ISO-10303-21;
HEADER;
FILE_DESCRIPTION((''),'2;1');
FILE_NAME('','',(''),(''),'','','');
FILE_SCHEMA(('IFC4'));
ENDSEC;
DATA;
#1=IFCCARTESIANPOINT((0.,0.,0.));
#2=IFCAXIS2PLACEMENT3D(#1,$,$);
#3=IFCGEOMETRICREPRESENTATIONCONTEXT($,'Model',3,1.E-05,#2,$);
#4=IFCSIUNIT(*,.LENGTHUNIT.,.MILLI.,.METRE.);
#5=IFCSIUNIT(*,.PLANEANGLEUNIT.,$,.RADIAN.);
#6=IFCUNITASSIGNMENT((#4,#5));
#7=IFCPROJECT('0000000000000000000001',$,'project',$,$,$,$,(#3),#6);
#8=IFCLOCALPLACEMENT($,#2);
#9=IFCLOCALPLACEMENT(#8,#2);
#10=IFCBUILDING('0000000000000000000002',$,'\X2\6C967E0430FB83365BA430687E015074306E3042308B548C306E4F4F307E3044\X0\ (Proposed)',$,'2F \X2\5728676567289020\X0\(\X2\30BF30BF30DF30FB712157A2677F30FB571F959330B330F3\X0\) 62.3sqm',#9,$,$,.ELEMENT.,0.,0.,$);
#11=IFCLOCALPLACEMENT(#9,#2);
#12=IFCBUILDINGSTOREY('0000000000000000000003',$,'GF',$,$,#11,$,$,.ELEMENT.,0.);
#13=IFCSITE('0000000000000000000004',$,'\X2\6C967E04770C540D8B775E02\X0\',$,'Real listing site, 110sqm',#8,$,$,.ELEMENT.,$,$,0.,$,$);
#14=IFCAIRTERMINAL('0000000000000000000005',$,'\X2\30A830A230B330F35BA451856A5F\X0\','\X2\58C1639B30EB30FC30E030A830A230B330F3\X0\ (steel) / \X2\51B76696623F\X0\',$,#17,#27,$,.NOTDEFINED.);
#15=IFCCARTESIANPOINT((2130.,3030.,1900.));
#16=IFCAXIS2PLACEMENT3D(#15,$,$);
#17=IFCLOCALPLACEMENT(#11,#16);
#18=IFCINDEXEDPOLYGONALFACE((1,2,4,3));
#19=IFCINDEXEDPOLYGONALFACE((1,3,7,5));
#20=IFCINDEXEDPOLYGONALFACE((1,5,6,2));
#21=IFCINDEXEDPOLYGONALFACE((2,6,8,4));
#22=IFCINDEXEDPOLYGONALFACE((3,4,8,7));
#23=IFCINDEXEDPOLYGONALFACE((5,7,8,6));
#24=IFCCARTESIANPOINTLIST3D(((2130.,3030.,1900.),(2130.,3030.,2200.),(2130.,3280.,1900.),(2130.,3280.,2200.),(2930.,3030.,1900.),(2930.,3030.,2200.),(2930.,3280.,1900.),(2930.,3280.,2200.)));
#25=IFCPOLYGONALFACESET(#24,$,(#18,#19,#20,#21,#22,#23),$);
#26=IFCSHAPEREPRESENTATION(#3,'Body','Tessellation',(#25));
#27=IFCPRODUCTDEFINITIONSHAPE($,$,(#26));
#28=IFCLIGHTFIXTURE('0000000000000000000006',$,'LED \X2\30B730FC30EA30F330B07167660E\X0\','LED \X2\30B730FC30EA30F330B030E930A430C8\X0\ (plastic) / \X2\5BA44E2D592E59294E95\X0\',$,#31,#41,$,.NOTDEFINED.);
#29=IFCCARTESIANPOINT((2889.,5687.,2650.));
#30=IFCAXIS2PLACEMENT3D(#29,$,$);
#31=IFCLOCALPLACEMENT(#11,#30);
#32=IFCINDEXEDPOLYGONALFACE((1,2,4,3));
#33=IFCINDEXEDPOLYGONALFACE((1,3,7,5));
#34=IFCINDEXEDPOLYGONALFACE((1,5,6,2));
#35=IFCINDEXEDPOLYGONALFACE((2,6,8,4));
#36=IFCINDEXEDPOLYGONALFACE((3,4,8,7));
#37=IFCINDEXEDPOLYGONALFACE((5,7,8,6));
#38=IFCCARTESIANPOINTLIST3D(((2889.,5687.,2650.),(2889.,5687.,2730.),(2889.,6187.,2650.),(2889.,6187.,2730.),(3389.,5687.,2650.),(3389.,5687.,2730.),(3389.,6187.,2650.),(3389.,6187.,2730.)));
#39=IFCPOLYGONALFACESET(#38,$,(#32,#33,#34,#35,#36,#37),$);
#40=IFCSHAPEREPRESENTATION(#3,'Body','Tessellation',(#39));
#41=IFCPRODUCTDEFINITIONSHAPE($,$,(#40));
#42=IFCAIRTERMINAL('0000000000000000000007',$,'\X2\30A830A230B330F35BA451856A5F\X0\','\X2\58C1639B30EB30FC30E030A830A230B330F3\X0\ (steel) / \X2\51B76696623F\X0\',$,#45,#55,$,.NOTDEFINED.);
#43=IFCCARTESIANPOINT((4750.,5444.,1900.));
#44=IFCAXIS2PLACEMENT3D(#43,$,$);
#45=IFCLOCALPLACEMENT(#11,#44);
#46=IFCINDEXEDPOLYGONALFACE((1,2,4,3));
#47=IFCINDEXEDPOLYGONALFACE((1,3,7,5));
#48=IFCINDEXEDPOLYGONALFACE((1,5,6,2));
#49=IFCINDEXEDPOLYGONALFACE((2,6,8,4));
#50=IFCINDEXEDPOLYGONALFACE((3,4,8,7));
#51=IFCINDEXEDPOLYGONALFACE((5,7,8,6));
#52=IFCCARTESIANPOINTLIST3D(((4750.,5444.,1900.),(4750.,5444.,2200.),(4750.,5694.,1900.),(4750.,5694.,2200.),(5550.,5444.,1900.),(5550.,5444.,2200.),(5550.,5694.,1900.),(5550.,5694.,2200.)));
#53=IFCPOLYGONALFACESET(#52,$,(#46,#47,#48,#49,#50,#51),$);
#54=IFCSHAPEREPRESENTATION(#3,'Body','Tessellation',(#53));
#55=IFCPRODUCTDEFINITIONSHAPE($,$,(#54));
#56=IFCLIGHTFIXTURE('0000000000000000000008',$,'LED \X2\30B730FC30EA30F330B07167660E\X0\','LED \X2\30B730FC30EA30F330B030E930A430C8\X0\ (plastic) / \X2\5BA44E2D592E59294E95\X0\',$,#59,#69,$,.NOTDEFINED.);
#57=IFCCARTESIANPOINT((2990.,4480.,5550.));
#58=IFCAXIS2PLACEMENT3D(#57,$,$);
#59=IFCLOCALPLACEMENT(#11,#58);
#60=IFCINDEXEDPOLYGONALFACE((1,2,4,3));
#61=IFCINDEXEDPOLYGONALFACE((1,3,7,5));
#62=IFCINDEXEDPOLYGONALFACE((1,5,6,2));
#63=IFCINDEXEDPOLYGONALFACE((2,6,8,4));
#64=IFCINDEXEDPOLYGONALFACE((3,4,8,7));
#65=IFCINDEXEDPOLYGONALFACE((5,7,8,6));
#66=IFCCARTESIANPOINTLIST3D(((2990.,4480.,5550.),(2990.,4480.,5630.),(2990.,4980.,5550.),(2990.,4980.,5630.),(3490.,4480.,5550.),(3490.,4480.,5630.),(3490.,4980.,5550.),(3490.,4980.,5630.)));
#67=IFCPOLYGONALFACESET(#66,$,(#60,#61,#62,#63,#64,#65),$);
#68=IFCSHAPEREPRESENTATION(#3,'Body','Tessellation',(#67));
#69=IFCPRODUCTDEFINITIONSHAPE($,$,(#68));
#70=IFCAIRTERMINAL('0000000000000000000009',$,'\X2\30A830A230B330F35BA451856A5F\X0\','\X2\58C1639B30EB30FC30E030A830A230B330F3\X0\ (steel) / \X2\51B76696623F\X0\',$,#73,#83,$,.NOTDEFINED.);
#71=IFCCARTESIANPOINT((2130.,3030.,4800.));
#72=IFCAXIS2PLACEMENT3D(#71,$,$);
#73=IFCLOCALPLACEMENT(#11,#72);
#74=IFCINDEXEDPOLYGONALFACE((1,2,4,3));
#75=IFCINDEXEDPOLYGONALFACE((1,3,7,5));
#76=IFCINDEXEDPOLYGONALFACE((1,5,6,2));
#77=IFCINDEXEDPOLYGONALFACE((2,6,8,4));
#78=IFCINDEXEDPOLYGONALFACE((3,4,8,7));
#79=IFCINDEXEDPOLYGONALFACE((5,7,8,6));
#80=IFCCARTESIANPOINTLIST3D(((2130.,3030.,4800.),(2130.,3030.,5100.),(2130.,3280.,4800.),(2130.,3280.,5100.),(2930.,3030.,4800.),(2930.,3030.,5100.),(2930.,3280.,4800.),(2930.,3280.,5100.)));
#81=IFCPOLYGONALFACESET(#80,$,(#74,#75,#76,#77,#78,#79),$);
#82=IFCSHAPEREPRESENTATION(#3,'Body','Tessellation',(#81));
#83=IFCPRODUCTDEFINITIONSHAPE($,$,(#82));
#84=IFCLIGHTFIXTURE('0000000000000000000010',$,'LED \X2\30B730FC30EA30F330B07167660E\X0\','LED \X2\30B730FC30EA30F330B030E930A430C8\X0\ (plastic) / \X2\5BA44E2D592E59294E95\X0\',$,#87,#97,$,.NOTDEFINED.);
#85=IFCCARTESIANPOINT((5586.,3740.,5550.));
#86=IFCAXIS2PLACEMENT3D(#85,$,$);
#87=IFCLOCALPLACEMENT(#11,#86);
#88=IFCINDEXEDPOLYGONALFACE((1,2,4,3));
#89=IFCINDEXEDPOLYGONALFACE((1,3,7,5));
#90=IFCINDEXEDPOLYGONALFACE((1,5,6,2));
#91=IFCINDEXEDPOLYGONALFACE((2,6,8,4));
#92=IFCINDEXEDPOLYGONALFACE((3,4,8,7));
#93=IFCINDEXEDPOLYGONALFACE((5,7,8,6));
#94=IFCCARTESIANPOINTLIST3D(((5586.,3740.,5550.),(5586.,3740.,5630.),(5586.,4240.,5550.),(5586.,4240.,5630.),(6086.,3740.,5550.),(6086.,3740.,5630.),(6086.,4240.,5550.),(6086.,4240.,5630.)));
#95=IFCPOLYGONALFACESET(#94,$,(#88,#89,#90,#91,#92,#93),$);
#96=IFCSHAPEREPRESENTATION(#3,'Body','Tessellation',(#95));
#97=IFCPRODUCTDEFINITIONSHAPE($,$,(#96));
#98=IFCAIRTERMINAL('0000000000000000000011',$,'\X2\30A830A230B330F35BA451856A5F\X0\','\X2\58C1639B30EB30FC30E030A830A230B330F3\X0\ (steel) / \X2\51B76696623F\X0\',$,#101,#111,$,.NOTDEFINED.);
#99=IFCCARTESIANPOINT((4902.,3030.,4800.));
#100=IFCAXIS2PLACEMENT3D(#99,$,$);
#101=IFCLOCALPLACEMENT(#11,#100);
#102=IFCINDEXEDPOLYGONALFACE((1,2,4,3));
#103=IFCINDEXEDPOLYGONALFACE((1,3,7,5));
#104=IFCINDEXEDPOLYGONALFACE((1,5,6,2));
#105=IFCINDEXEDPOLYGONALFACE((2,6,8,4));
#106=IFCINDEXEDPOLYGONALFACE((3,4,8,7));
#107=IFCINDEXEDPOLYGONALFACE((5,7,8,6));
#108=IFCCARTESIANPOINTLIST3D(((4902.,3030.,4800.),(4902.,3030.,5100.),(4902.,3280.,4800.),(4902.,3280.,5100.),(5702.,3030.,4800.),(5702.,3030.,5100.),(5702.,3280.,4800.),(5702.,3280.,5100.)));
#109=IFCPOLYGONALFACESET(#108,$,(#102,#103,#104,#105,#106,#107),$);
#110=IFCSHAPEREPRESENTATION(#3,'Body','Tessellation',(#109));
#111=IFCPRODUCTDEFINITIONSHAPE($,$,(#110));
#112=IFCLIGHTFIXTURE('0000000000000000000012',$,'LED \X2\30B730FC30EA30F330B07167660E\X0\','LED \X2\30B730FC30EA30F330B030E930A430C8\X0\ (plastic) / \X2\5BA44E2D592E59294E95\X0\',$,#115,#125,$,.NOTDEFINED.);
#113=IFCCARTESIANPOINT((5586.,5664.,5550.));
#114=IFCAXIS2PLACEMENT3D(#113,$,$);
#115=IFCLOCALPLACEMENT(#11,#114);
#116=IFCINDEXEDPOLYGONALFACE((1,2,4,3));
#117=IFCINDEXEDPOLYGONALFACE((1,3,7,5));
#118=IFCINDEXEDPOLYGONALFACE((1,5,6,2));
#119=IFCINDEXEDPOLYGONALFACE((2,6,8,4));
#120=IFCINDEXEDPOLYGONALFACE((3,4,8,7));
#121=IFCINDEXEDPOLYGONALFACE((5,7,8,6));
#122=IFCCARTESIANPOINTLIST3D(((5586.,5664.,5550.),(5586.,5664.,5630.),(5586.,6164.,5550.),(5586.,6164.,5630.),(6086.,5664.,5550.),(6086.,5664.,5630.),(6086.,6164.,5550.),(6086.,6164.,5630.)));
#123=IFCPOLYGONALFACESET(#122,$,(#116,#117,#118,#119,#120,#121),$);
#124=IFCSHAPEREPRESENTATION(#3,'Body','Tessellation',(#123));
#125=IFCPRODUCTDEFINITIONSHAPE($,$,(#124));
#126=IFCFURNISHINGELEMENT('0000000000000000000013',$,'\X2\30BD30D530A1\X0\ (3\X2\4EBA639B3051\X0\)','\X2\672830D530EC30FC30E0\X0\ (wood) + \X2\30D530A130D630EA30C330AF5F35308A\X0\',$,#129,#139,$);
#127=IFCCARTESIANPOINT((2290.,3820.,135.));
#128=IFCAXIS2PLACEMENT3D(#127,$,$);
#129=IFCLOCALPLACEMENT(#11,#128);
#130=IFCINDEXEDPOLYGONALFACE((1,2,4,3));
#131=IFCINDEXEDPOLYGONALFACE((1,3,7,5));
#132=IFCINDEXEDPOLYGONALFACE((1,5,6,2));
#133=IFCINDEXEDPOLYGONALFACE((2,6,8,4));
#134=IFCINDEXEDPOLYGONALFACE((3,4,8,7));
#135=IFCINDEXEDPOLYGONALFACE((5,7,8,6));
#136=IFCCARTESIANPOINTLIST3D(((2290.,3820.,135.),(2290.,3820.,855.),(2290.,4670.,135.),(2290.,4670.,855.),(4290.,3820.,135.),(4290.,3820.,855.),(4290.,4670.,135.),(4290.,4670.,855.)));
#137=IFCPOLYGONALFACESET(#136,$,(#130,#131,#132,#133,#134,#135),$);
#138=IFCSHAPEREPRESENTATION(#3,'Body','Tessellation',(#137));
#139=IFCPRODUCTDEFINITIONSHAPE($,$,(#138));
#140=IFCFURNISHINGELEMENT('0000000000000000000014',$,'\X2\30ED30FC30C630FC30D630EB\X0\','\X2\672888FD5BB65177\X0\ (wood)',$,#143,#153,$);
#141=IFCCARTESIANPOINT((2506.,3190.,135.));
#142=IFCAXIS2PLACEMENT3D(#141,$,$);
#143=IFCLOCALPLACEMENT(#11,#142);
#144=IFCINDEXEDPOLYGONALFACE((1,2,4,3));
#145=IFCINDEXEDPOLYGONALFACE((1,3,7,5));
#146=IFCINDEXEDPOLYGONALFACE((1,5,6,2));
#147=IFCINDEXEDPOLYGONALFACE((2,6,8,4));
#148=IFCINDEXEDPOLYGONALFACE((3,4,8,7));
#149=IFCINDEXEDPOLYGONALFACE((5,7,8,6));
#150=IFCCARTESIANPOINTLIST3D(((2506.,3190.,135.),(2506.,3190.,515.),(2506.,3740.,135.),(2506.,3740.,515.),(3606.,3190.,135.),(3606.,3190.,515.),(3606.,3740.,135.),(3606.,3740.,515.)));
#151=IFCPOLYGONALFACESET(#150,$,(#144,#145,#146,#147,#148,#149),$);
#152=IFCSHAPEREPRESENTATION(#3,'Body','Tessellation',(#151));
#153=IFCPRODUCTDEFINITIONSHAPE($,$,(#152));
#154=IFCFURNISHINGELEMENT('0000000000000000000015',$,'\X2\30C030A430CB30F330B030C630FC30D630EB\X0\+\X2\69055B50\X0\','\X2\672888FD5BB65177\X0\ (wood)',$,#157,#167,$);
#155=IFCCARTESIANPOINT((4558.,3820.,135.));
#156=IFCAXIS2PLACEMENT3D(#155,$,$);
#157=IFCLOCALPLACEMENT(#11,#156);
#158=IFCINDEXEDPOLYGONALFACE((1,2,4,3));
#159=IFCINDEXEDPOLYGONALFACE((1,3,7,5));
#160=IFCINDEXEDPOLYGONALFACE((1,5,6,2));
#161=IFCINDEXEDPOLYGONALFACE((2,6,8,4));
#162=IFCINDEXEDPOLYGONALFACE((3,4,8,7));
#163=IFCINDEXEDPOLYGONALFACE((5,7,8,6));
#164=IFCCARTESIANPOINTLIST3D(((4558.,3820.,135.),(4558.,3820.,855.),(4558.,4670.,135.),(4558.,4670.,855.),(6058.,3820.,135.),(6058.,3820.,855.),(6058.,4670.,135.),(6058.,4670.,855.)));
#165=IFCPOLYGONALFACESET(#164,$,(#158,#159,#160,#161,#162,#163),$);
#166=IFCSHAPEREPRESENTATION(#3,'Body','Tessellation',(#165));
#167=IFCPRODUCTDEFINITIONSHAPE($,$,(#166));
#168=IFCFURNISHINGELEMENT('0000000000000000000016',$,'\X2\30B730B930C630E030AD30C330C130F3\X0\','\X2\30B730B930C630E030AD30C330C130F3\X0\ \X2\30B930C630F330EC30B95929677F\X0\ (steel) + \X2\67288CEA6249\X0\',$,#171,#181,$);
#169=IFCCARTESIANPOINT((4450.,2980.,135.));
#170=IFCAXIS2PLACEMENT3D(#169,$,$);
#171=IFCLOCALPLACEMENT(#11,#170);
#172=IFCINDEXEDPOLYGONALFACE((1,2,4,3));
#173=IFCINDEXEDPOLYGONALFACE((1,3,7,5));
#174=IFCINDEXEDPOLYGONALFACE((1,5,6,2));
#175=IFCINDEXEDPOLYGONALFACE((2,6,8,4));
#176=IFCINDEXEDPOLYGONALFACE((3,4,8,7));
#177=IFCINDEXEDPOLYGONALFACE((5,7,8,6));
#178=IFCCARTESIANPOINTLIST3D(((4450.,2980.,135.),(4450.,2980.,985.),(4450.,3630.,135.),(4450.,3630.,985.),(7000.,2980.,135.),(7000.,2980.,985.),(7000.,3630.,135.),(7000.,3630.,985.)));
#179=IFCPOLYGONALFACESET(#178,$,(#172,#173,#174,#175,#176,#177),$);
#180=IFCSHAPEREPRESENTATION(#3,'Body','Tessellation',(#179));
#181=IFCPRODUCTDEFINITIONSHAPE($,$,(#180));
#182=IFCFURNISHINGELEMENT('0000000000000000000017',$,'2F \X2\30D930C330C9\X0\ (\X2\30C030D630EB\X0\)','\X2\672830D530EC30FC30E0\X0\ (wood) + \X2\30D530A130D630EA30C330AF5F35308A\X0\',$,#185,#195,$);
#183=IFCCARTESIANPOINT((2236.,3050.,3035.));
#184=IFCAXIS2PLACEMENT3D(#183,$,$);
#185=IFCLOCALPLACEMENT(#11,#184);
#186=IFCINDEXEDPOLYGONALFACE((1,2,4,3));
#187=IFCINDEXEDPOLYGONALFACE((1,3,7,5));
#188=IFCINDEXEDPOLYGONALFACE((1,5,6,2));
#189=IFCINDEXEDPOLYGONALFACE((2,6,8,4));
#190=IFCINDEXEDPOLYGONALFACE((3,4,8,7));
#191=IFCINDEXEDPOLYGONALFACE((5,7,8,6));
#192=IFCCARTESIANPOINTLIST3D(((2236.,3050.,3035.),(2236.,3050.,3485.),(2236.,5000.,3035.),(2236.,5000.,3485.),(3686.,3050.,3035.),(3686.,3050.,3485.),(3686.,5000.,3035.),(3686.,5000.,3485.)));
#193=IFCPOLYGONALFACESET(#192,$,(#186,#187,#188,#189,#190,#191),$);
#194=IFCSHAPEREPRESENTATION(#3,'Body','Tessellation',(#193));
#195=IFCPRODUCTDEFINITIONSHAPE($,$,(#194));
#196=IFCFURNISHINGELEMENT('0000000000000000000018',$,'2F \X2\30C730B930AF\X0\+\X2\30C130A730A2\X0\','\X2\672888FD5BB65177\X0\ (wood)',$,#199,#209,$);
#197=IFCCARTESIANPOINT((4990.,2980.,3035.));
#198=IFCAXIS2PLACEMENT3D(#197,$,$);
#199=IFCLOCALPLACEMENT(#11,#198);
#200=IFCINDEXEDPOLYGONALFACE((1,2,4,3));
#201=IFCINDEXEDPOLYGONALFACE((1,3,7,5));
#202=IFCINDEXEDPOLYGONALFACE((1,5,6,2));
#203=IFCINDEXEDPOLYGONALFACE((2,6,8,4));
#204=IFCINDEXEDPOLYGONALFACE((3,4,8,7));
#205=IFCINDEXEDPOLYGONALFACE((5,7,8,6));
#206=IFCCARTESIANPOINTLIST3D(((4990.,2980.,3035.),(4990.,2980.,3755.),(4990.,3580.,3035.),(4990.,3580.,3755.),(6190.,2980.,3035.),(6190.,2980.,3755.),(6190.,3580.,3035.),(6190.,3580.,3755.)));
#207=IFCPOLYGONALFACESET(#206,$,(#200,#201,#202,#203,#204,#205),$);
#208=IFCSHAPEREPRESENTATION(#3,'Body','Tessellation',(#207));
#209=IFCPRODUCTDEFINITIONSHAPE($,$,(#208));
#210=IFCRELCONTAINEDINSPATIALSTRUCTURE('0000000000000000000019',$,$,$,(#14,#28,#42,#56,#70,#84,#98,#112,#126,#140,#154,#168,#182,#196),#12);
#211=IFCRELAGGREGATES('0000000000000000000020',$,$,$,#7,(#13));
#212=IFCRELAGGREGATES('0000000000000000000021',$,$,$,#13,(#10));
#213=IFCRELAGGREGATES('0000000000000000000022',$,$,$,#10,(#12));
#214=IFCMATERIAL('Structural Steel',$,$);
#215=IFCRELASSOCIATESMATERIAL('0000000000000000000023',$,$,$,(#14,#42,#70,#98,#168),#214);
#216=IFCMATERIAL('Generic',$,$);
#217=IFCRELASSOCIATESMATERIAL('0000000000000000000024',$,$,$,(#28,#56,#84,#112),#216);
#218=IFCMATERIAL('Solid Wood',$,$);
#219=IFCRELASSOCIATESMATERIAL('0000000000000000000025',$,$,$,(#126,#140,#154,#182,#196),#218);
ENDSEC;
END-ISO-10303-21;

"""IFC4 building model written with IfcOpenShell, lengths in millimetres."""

from ifc_helpers import new_model, si_unit, frame, frame_2d, origin, place, context, project, spatial, rectangle, extrude, material, element, save


model = new_model("IFC4")

# Units and contexts
model_context = context("Model", 3, precision=1e-05, world=origin())
ifc_project = project(units=[si_unit("LENGTHUNIT", "METRE", prefix="MILLI"), si_unit("PLANEANGLEUNIT", "RADIAN")], contexts=[model_context])

# Site, building, storey
site_placement = place(None, origin())
site = spatial("IfcSite", under=ifc_project, at=site_placement, Name="沖縄県名護市", ObjectType="Real listing site, 110sqm", CompositionType="ELEMENT", RefElevation=0.0)
building_placement = place(site_placement, origin())
building = spatial("IfcBuilding", under=site, at=building_placement, Name="沖縄・茶室と縁側のある和の住まい (Proposed)", ObjectType="2F 在来木造(タタミ・無垢板・土間コン) 62.3sqm", CompositionType="ELEMENT", ElevationOfRefHeight=0.0, ElevationOfTerrain=0.0)
storey_placement = place(building_placement, origin())
storey = spatial("IfcBuildingStorey", under=building, at=storey_placement, Name="GF", CompositionType="ELEMENT", Elevation=0.0)

# Shared definitions
ifc_material_1 = material(Name="Solid Wood")

# Shared definitions
ifc_material_2 = material(Name="Structural Steel")

# Shared definitions
ifc_material_3 = material(Name="Generic")

# Air terminal
air_terminal_1_placement = place(storey_placement, frame((2130.0, 3030.0, 1900.0)))
element("IfcAirTerminal", 1, at=air_terminal_1_placement, inside=storey, material=ifc_material_2, Name="エアコン室内機", Description="壁掛ルームエアコン (steel) / 冷暖房", PredefinedType="NOTDEFINED", context=model_context, shape_type="SweptSolid", body=[
    extrude(rectangle(XDim=800.0, YDim=250.0, at=frame_2d((400.0, 125.0))), frame((2130.0, 3030.0, 1900.0)), (0.0, 0.0, 1.0), 300.0),
])

# Light fixture
light_fixture_1_placement = place(storey_placement, frame((2889.0, 5687.0, 2650.0)))
element("IfcLightFixture", 2, at=light_fixture_1_placement, inside=storey, material=ifc_material_3, Name="LED シーリング照明", Description="LED シーリングライト (plastic) / 室中央天井", PredefinedType="NOTDEFINED", context=model_context, shape_type="SweptSolid", body=[
    extrude(rectangle(XDim=500.0, YDim=500.0, at=frame_2d((250.0, 250.0))), frame((2889.0, 5687.0, 2650.0)), (0.0, 0.0, 1.0), 80.0),
])

# Air terminal
air_terminal_2_placement = place(storey_placement, frame((4750.0, 5444.0, 1900.0)))
element("IfcAirTerminal", 3, at=air_terminal_2_placement, inside=storey, material=ifc_material_2, Name="エアコン室内機", Description="壁掛ルームエアコン (steel) / 冷暖房", PredefinedType="NOTDEFINED", context=model_context, shape_type="SweptSolid", body=[
    extrude(rectangle(XDim=800.0, YDim=250.0, at=frame_2d((400.0, 125.0))), frame((4750.0, 5444.0, 1900.0)), (0.0, 0.0, 1.0), 300.0),
])

# Light fixture
light_fixture_2_placement = place(storey_placement, frame((2990.0, 4480.0, 5550.0)))
element("IfcLightFixture", 4, at=light_fixture_2_placement, inside=storey, material=ifc_material_3, Name="LED シーリング照明", Description="LED シーリングライト (plastic) / 室中央天井", PredefinedType="NOTDEFINED", context=model_context, shape_type="SweptSolid", body=[
    extrude(rectangle(XDim=500.0, YDim=500.0, at=frame_2d((250.0, 250.0))), frame((2990.0, 4480.0, 5550.0)), (0.0, 0.0, 1.0), 80.0),
])

# Air terminal
air_terminal_3_placement = place(storey_placement, frame((2130.0, 3030.0, 4800.0)))
element("IfcAirTerminal", 5, at=air_terminal_3_placement, inside=storey, material=ifc_material_2, Name="エアコン室内機", Description="壁掛ルームエアコン (steel) / 冷暖房", PredefinedType="NOTDEFINED", context=model_context, shape_type="SweptSolid", body=[
    extrude(rectangle(XDim=800.0, YDim=250.0, at=frame_2d((400.0, 125.0))), frame((2130.0, 3030.0, 4800.0)), (0.0, 0.0, 1.0), 300.0),
])

# Light fixture
light_fixture_3_placement = place(storey_placement, frame((5586.0, 3740.0, 5550.0)))
element("IfcLightFixture", 6, at=light_fixture_3_placement, inside=storey, material=ifc_material_3, Name="LED シーリング照明", Description="LED シーリングライト (plastic) / 室中央天井", PredefinedType="NOTDEFINED", context=model_context, shape_type="SweptSolid", body=[
    extrude(rectangle(XDim=500.0, YDim=500.0, at=frame_2d((250.0, 250.0))), frame((5586.0, 3740.0, 5550.0)), (0.0, 0.0, 1.0), 80.0),
])

# Air terminal
air_terminal_4_placement = place(storey_placement, frame((4902.0, 3030.0, 4800.0)))
element("IfcAirTerminal", 7, at=air_terminal_4_placement, inside=storey, material=ifc_material_2, Name="エアコン室内機", Description="壁掛ルームエアコン (steel) / 冷暖房", PredefinedType="NOTDEFINED", context=model_context, shape_type="SweptSolid", body=[
    extrude(rectangle(XDim=800.0, YDim=250.0, at=frame_2d((400.0, 125.0))), frame((4902.0, 3030.0, 4800.0)), (0.0, 0.0, 1.0), 300.0),
])

# Light fixture
light_fixture_4_placement = place(storey_placement, frame((5586.0, 5664.0, 5550.0)))
element("IfcLightFixture", 8, at=light_fixture_4_placement, inside=storey, material=ifc_material_3, Name="LED シーリング照明", Description="LED シーリングライト (plastic) / 室中央天井", PredefinedType="NOTDEFINED", context=model_context, shape_type="SweptSolid", body=[
    extrude(rectangle(XDim=500.0, YDim=500.0, at=frame_2d((250.0, 250.0))), frame((5586.0, 5664.0, 5550.0)), (0.0, 0.0, 1.0), 80.0),
])

# Furnishing elements
furnishing_1_placement = place(storey_placement, frame((2290.0, 3820.0, 135.0)))
element("IfcFurnishingElement", 9, at=furnishing_1_placement, inside=storey, material=ifc_material_1, Name="ソファ (3人掛け)", Description="木フレーム (wood) + ファブリック張り", context=model_context, shape_type="SweptSolid", body=[
    extrude(rectangle(XDim=2000.0, YDim=850.0, at=frame_2d((1000.0, 425.0))), frame((2290.0, 3820.0, 135.0)), (0.0, 0.0, 1.0), 720.0),
])
furnishing_2_placement = place(storey_placement, frame((2506.0, 3190.0, 135.0)))
element("IfcFurnishingElement", 10, at=furnishing_2_placement, inside=storey, material=ifc_material_1, Name="ローテーブル", Description="木製家具 (wood)", context=model_context, shape_type="SweptSolid", body=[
    extrude(rectangle(XDim=1100.0, YDim=550.0, at=frame_2d((550.0, 275.0))), frame((2506.0, 3190.0, 135.0)), (0.0, 0.0, 1.0), 380.0),
])
furnishing_3_placement = place(storey_placement, frame((4558.0, 3820.0, 135.0)))
element("IfcFurnishingElement", 11, at=furnishing_3_placement, inside=storey, material=ifc_material_1, Name="ダイニングテーブル+椅子", Description="木製家具 (wood)", context=model_context, shape_type="SweptSolid", body=[
    extrude(rectangle(XDim=1500.0, YDim=850.0, at=frame_2d((750.0, 425.0))), frame((4558.0, 3820.0, 135.0)), (0.0, 0.0, 1.0), 720.0),
])
furnishing_4_placement = place(storey_placement, frame((4450.0, 2980.0, 135.0)))
element("IfcFurnishingElement", 12, at=furnishing_4_placement, inside=storey, material=ifc_material_2, Name="システムキッチン", Description="システムキッチン ステンレス天板 (steel) + 木質扉", context=model_context, shape_type="SweptSolid", body=[
    extrude(rectangle(XDim=2550.0, YDim=650.0, at=frame_2d((1275.0, 325.0))), frame((4450.0, 2980.0, 135.0)), (0.0, 0.0, 1.0), 850.0),
])
furnishing_5_placement = place(storey_placement, frame((2236.0, 3050.0, 3035.0)))
element("IfcFurnishingElement", 13, at=furnishing_5_placement, inside=storey, material=ifc_material_1, Name="2F ベッド (ダブル)", Description="木フレーム (wood) + ファブリック張り", context=model_context, shape_type="SweptSolid", body=[
    extrude(rectangle(XDim=1450.0, YDim=1950.0, at=frame_2d((725.0, 975.0))), frame((2236.0, 3050.0, 3035.0)), (0.0, 0.0, 1.0), 450.0),
])
furnishing_6_placement = place(storey_placement, frame((4990.0, 2980.0, 3035.0)))
element("IfcFurnishingElement", 14, at=furnishing_6_placement, inside=storey, material=ifc_material_1, Name="2F デスク+チェア", Description="木製家具 (wood)", context=model_context, shape_type="SweptSolid", body=[
    extrude(rectangle(XDim=1200.0, YDim=600.0, at=frame_2d((600.0, 300.0))), frame((4990.0, 2980.0, 3035.0)), (0.0, 0.0, 1.0), 720.0),
])

save(model, "model.ifc")
